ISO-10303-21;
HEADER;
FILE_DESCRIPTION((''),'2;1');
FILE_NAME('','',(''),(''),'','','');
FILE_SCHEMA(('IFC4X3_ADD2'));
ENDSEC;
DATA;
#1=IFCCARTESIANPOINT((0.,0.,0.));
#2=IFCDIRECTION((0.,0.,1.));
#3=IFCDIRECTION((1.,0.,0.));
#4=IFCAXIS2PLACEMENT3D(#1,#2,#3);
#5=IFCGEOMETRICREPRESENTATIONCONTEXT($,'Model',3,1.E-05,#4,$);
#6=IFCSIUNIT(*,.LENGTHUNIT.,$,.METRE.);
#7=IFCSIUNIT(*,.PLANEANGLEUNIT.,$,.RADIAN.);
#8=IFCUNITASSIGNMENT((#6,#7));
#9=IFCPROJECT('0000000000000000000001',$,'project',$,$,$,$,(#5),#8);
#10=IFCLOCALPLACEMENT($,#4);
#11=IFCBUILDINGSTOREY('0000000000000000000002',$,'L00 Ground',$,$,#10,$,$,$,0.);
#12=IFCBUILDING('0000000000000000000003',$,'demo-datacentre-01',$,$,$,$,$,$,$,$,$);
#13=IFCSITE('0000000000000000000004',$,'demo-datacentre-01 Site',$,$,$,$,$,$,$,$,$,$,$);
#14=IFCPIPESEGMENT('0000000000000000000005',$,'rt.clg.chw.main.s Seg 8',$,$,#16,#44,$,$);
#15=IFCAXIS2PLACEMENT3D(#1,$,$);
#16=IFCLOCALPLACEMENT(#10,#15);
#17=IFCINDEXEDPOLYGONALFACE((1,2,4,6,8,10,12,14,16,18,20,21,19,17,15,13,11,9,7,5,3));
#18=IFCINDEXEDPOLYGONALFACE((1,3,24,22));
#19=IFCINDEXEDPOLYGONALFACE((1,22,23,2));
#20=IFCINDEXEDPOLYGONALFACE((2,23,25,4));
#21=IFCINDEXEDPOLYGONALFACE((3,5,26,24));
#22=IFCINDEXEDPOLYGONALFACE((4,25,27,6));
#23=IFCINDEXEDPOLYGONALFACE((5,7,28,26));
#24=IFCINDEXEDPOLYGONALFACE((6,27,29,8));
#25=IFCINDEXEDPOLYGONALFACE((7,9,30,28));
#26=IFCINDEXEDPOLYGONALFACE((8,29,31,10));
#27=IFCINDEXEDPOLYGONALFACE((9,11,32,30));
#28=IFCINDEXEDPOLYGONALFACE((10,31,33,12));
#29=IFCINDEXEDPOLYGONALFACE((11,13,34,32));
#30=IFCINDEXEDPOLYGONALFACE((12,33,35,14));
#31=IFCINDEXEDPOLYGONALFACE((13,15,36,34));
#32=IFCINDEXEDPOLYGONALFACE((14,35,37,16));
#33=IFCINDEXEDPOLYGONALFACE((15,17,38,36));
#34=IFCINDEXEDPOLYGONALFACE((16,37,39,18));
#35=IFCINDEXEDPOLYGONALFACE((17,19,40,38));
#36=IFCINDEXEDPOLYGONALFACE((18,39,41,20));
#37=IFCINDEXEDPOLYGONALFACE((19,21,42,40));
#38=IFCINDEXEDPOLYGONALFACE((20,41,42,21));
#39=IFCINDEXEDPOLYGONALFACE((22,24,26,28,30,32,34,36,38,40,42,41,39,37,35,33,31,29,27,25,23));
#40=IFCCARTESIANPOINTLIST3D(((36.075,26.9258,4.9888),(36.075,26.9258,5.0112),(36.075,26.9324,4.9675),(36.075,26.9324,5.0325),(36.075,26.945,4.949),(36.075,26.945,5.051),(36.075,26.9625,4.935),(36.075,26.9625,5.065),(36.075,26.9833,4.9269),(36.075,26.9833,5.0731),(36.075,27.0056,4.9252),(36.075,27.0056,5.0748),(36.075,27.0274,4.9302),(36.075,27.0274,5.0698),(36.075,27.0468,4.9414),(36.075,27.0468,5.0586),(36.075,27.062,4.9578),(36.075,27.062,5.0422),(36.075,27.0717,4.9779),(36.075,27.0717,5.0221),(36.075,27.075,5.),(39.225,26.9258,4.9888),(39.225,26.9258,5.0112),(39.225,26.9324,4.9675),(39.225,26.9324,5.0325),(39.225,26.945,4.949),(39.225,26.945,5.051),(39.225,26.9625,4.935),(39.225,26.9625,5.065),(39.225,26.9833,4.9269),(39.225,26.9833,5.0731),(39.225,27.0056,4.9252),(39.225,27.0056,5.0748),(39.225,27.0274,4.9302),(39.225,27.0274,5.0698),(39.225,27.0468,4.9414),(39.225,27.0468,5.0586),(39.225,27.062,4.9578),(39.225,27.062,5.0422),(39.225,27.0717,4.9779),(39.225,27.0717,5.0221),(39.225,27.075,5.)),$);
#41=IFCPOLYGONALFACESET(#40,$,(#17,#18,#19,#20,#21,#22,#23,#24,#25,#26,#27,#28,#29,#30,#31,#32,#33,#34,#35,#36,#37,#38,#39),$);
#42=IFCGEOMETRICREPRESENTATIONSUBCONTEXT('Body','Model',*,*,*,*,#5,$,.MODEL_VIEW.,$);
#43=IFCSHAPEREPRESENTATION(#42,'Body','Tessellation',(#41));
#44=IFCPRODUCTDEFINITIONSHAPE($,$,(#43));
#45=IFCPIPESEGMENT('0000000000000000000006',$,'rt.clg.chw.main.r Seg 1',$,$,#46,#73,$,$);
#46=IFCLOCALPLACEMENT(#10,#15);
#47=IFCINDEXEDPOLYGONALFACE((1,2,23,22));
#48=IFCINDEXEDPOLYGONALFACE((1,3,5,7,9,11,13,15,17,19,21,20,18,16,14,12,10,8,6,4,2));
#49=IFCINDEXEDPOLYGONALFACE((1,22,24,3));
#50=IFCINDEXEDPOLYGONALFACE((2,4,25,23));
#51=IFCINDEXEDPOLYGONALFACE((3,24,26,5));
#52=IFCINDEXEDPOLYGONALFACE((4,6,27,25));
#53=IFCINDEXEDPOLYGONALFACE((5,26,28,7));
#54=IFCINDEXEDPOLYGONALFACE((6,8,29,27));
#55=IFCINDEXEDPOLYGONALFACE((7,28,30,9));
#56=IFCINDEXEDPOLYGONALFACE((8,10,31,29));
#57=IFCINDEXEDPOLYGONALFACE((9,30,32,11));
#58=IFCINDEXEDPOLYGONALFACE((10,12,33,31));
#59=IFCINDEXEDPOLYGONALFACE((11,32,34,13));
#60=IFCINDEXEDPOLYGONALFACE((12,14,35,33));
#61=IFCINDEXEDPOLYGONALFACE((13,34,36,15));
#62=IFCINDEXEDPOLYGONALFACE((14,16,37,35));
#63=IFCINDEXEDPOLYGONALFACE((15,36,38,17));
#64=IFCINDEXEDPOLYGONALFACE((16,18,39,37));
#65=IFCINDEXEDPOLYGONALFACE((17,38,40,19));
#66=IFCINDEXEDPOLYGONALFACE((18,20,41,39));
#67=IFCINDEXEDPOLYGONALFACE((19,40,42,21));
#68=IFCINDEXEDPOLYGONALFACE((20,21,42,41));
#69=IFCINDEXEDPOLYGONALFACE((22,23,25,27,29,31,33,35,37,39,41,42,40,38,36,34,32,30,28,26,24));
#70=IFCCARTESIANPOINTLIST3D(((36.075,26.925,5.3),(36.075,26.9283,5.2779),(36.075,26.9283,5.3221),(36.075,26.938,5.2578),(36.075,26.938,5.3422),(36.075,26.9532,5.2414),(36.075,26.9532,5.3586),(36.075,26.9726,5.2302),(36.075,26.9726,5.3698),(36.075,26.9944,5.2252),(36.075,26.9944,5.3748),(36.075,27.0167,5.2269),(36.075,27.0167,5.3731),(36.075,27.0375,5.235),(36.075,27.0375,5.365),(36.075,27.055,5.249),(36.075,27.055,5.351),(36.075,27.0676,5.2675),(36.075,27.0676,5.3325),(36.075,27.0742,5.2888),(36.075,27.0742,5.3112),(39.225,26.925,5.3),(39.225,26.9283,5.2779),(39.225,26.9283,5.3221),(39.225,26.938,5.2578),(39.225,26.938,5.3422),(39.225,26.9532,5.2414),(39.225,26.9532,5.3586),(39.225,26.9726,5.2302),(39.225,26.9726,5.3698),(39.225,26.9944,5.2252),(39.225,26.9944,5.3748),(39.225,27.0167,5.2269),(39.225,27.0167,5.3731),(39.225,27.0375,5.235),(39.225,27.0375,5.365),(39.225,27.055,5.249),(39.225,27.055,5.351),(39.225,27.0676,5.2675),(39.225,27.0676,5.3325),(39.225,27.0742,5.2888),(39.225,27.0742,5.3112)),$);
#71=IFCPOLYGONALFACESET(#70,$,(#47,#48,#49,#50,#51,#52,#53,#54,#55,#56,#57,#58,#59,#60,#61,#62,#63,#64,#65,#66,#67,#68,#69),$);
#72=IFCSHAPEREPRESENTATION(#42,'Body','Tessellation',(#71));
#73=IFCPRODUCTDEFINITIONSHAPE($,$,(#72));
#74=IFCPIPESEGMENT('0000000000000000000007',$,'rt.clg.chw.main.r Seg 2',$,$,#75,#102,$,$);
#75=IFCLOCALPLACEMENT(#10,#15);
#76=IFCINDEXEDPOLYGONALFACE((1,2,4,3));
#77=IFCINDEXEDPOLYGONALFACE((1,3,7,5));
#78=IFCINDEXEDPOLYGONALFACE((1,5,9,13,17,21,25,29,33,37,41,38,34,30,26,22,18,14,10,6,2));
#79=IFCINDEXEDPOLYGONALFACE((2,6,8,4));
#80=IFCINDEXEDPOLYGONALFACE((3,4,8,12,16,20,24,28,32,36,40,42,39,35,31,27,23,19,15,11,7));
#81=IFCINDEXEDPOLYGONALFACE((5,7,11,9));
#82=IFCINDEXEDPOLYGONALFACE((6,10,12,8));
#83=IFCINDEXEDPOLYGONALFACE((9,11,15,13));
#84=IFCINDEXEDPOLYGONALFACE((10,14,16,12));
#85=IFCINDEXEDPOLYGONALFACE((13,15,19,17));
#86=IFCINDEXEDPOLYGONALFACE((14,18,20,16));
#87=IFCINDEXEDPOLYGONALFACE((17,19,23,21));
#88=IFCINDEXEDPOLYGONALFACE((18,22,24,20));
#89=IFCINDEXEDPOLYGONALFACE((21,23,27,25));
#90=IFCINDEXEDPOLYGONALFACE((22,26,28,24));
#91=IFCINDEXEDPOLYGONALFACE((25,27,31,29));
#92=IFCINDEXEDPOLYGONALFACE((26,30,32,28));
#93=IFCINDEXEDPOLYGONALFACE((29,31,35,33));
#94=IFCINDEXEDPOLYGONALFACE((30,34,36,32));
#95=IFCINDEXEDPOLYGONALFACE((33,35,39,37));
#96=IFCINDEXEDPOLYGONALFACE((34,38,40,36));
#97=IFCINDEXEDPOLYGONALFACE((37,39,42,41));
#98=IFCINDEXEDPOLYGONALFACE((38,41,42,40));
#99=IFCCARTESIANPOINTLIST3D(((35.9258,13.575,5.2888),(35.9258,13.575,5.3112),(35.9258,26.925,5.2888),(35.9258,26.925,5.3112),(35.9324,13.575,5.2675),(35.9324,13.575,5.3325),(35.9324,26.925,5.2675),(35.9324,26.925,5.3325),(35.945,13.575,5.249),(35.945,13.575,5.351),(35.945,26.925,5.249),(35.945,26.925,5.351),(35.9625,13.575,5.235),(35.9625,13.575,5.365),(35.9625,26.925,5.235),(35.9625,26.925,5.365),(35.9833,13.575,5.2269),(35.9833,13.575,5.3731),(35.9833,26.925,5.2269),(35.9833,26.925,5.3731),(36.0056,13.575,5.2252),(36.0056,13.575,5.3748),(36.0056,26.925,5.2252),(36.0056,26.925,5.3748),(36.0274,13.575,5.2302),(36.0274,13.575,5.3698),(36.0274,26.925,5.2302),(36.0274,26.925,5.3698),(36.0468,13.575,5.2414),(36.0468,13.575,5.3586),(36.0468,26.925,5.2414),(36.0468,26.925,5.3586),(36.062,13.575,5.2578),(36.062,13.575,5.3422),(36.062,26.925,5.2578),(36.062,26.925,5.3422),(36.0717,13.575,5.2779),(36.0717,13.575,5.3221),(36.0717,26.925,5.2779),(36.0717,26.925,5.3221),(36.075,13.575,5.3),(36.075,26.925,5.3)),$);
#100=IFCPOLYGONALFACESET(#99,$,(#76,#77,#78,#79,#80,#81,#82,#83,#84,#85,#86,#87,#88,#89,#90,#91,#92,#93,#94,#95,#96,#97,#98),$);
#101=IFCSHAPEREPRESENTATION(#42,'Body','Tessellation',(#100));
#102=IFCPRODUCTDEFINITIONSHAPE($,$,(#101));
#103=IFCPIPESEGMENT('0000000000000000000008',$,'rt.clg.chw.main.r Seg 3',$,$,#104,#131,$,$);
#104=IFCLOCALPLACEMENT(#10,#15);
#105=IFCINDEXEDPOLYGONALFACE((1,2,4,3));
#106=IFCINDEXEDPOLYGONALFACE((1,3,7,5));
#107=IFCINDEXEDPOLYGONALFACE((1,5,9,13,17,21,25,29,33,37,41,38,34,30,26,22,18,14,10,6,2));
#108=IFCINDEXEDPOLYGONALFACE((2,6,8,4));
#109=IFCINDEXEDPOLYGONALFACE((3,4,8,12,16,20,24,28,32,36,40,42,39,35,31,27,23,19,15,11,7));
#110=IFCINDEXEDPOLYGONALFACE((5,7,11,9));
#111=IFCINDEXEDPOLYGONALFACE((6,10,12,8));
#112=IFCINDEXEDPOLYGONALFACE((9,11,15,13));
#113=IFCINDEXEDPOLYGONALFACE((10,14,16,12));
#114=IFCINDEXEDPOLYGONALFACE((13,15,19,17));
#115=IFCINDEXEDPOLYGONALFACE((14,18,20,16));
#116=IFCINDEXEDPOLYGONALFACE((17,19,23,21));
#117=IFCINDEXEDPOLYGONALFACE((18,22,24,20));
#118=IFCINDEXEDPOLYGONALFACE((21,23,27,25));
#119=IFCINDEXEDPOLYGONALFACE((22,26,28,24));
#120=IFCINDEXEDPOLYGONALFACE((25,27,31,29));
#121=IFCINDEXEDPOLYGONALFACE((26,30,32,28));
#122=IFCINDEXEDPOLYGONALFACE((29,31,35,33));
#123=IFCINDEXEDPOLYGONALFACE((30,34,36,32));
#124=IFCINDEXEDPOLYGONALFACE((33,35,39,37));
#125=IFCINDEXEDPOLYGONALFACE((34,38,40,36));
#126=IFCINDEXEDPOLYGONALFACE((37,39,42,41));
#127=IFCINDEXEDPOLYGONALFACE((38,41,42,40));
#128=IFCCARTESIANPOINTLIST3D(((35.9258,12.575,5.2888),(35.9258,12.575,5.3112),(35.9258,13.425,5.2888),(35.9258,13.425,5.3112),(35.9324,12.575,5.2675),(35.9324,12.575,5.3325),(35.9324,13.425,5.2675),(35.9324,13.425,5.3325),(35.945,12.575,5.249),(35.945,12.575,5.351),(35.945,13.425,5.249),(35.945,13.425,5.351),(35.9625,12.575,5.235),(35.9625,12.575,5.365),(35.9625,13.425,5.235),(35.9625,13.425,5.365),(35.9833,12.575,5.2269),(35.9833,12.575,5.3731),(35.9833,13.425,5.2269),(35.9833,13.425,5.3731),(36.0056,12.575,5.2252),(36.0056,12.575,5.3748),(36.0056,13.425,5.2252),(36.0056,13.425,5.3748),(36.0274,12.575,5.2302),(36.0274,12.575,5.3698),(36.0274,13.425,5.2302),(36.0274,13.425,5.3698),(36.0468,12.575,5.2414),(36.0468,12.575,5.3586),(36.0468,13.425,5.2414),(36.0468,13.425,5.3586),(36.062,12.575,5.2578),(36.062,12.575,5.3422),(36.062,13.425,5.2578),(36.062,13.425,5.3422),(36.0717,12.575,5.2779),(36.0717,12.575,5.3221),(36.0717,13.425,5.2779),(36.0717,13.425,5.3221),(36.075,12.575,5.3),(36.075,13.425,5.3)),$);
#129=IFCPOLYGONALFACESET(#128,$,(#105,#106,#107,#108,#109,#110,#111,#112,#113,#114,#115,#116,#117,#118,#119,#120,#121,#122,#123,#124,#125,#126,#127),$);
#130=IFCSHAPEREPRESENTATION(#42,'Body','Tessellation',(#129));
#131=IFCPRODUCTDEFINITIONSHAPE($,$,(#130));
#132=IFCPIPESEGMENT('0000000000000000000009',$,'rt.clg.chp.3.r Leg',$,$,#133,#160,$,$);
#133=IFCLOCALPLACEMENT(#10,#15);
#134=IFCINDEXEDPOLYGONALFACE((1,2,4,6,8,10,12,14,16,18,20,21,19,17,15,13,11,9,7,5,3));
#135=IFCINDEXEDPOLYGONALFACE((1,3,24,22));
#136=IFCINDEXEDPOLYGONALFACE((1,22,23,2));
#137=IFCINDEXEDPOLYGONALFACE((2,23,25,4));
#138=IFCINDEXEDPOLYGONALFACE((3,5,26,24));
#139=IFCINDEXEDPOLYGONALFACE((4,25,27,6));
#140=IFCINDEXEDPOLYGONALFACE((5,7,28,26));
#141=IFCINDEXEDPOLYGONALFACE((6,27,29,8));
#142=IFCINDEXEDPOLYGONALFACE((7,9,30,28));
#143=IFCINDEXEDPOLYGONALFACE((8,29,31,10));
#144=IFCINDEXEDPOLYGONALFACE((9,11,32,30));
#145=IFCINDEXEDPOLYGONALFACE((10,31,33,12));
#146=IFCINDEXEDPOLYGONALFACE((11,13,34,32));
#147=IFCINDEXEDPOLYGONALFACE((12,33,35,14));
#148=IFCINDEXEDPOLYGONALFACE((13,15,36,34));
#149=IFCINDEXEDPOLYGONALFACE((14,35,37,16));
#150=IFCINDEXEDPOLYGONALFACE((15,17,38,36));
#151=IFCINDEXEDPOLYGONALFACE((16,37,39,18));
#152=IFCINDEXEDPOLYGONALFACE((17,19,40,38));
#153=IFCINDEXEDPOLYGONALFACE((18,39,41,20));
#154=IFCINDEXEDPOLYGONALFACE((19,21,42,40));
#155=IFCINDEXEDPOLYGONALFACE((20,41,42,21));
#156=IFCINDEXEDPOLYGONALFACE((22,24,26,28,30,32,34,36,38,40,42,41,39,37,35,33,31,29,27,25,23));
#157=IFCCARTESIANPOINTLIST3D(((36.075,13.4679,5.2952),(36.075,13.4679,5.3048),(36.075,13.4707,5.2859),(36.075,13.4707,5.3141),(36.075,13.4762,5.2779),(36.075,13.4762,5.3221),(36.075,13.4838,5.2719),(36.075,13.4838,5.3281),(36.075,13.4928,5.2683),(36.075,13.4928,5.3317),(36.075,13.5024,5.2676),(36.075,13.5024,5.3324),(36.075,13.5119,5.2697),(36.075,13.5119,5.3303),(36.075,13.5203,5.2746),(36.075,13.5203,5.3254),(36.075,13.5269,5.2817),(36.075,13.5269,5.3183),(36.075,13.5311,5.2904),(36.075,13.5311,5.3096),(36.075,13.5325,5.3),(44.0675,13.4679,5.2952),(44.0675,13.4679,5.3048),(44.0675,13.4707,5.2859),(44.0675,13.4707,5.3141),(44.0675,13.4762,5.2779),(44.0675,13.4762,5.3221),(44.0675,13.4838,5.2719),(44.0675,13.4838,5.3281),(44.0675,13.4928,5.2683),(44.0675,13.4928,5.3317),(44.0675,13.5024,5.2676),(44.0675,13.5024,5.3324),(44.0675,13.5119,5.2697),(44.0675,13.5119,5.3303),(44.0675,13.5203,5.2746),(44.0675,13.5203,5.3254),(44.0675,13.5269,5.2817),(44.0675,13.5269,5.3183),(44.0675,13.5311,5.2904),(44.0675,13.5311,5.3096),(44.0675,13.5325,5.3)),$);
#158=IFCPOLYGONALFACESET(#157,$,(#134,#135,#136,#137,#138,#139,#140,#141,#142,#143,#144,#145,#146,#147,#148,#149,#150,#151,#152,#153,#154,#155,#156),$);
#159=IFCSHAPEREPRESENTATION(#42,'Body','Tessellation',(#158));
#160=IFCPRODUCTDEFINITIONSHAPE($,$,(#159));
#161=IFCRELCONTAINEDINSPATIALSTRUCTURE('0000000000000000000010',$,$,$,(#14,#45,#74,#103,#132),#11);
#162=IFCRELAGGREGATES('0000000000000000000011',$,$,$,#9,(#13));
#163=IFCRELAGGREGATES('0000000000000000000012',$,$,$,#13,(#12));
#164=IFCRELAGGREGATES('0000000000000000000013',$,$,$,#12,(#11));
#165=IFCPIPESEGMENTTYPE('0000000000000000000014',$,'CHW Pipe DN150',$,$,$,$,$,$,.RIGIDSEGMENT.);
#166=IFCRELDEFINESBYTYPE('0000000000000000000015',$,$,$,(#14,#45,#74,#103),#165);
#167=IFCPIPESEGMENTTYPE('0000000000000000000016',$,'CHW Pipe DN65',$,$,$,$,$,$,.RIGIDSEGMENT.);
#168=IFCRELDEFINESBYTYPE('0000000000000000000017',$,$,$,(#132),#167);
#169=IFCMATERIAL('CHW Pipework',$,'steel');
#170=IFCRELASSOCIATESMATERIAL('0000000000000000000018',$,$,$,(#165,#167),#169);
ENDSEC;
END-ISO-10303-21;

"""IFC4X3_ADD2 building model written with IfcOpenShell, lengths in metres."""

from ifc_helpers import new_model, si_unit, frame, origin_with_axes, place, context, subcontext, project, spatial, circle, extrude, material, type_object, element, save


model = new_model("IFC4X3_ADD2")

# Units and contexts
model_context = context("Model", 3, precision=1e-05, world=origin_with_axes())
body_context = subcontext(model_context, "Body", "Model", "MODEL_VIEW")
ifc_project = project(units=[si_unit("LENGTHUNIT", "METRE"), si_unit("PLANEANGLEUNIT", "RADIAN")], contexts=[model_context])

# Site, building, storey
site = spatial("IfcSite", under=ifc_project, Name="demo-datacentre-01 Site")
building = spatial("IfcBuilding", under=site, Name="demo-datacentre-01")
storey_placement = place(None, origin_with_axes())
storey = spatial("IfcBuildingStorey", under=building, at=storey_placement, Name="L00 Ground", Elevation=0.0)

# Shared definitions
ifc_material_1 = material(Name="CHW Pipework", Category="steel")

# Pipe segments
pipe_segment_type_1 = type_object("IfcPipeSegmentType", Name="CHW Pipe DN150", PredefinedType="RIGIDSEGMENT", material=ifc_material_1)
for number, where, z_axis, x_axis, name in (
    (1, (36.075, 27.0, 5.0), (1.0, 0.0, 0.0), (0.0, 1.0, 0.0), "rt.clg.chw.main.s Seg 8"),
    (2, (39.225, 27.0, 5.3), (-1.0, 0.0, 0.0), (0.0, -1.0, 0.0), "rt.clg.chw.main.r Seg 1"),
):
    element("IfcPipeSegment", number, at=place(storey_placement, frame(where, z_axis=z_axis, x_axis=x_axis)), inside=storey, type_object=pipe_segment_type_1, Name=name, context=body_context, shape_type="SweptSolid", body=[
        extrude(circle(Radius=0.075), origin_with_axes(), (0.0, 0.0, 1.0), 3.15),
    ])
pipe_segment_1_placement = place(storey_placement, frame((36.0, 26.925, 5.3), z_axis=(0.0, -1.0, 0.0), x_axis=(1.0, 0.0, 0.0)))
element("IfcPipeSegment", 3, at=pipe_segment_1_placement, inside=storey, type_object=pipe_segment_type_1, Name="rt.clg.chw.main.r Seg 2", context=body_context, shape_type="SweptSolid", body=[
    extrude(circle(Radius=0.075), origin_with_axes(), (0.0, 0.0, 1.0), 13.35),
])
pipe_segment_2_placement = place(storey_placement, frame((36.0, 13.425, 5.3), z_axis=(0.0, -1.0, 0.0), x_axis=(1.0, 0.0, 0.0)))
element("IfcPipeSegment", 4, at=pipe_segment_2_placement, inside=storey, type_object=pipe_segment_type_1, Name="rt.clg.chw.main.r Seg 3", context=body_context, shape_type="SweptSolid", body=[
    extrude(circle(Radius=0.075), origin_with_axes(), (0.0, 0.0, 1.0), 0.85),
])
pipe_segment_type_2 = type_object("IfcPipeSegmentType", Name="CHW Pipe DN65", PredefinedType="RIGIDSEGMENT", material=ifc_material_1)
pipe_segment_3_placement = place(storey_placement, frame((36.075, 13.5, 5.3), z_axis=(1.0, 0.0, 0.0), x_axis=(0.0, 1.0, 0.0)))
element("IfcPipeSegment", 5, at=pipe_segment_3_placement, inside=storey, type_object=pipe_segment_type_2, Name="rt.clg.chp.3.r Leg", context=body_context, shape_type="SweptSolid", body=[
    extrude(circle(Radius=0.0325), origin_with_axes(), (0.0, 0.0, 1.0), 7.9925),
])

save(model, "model.ifc")
